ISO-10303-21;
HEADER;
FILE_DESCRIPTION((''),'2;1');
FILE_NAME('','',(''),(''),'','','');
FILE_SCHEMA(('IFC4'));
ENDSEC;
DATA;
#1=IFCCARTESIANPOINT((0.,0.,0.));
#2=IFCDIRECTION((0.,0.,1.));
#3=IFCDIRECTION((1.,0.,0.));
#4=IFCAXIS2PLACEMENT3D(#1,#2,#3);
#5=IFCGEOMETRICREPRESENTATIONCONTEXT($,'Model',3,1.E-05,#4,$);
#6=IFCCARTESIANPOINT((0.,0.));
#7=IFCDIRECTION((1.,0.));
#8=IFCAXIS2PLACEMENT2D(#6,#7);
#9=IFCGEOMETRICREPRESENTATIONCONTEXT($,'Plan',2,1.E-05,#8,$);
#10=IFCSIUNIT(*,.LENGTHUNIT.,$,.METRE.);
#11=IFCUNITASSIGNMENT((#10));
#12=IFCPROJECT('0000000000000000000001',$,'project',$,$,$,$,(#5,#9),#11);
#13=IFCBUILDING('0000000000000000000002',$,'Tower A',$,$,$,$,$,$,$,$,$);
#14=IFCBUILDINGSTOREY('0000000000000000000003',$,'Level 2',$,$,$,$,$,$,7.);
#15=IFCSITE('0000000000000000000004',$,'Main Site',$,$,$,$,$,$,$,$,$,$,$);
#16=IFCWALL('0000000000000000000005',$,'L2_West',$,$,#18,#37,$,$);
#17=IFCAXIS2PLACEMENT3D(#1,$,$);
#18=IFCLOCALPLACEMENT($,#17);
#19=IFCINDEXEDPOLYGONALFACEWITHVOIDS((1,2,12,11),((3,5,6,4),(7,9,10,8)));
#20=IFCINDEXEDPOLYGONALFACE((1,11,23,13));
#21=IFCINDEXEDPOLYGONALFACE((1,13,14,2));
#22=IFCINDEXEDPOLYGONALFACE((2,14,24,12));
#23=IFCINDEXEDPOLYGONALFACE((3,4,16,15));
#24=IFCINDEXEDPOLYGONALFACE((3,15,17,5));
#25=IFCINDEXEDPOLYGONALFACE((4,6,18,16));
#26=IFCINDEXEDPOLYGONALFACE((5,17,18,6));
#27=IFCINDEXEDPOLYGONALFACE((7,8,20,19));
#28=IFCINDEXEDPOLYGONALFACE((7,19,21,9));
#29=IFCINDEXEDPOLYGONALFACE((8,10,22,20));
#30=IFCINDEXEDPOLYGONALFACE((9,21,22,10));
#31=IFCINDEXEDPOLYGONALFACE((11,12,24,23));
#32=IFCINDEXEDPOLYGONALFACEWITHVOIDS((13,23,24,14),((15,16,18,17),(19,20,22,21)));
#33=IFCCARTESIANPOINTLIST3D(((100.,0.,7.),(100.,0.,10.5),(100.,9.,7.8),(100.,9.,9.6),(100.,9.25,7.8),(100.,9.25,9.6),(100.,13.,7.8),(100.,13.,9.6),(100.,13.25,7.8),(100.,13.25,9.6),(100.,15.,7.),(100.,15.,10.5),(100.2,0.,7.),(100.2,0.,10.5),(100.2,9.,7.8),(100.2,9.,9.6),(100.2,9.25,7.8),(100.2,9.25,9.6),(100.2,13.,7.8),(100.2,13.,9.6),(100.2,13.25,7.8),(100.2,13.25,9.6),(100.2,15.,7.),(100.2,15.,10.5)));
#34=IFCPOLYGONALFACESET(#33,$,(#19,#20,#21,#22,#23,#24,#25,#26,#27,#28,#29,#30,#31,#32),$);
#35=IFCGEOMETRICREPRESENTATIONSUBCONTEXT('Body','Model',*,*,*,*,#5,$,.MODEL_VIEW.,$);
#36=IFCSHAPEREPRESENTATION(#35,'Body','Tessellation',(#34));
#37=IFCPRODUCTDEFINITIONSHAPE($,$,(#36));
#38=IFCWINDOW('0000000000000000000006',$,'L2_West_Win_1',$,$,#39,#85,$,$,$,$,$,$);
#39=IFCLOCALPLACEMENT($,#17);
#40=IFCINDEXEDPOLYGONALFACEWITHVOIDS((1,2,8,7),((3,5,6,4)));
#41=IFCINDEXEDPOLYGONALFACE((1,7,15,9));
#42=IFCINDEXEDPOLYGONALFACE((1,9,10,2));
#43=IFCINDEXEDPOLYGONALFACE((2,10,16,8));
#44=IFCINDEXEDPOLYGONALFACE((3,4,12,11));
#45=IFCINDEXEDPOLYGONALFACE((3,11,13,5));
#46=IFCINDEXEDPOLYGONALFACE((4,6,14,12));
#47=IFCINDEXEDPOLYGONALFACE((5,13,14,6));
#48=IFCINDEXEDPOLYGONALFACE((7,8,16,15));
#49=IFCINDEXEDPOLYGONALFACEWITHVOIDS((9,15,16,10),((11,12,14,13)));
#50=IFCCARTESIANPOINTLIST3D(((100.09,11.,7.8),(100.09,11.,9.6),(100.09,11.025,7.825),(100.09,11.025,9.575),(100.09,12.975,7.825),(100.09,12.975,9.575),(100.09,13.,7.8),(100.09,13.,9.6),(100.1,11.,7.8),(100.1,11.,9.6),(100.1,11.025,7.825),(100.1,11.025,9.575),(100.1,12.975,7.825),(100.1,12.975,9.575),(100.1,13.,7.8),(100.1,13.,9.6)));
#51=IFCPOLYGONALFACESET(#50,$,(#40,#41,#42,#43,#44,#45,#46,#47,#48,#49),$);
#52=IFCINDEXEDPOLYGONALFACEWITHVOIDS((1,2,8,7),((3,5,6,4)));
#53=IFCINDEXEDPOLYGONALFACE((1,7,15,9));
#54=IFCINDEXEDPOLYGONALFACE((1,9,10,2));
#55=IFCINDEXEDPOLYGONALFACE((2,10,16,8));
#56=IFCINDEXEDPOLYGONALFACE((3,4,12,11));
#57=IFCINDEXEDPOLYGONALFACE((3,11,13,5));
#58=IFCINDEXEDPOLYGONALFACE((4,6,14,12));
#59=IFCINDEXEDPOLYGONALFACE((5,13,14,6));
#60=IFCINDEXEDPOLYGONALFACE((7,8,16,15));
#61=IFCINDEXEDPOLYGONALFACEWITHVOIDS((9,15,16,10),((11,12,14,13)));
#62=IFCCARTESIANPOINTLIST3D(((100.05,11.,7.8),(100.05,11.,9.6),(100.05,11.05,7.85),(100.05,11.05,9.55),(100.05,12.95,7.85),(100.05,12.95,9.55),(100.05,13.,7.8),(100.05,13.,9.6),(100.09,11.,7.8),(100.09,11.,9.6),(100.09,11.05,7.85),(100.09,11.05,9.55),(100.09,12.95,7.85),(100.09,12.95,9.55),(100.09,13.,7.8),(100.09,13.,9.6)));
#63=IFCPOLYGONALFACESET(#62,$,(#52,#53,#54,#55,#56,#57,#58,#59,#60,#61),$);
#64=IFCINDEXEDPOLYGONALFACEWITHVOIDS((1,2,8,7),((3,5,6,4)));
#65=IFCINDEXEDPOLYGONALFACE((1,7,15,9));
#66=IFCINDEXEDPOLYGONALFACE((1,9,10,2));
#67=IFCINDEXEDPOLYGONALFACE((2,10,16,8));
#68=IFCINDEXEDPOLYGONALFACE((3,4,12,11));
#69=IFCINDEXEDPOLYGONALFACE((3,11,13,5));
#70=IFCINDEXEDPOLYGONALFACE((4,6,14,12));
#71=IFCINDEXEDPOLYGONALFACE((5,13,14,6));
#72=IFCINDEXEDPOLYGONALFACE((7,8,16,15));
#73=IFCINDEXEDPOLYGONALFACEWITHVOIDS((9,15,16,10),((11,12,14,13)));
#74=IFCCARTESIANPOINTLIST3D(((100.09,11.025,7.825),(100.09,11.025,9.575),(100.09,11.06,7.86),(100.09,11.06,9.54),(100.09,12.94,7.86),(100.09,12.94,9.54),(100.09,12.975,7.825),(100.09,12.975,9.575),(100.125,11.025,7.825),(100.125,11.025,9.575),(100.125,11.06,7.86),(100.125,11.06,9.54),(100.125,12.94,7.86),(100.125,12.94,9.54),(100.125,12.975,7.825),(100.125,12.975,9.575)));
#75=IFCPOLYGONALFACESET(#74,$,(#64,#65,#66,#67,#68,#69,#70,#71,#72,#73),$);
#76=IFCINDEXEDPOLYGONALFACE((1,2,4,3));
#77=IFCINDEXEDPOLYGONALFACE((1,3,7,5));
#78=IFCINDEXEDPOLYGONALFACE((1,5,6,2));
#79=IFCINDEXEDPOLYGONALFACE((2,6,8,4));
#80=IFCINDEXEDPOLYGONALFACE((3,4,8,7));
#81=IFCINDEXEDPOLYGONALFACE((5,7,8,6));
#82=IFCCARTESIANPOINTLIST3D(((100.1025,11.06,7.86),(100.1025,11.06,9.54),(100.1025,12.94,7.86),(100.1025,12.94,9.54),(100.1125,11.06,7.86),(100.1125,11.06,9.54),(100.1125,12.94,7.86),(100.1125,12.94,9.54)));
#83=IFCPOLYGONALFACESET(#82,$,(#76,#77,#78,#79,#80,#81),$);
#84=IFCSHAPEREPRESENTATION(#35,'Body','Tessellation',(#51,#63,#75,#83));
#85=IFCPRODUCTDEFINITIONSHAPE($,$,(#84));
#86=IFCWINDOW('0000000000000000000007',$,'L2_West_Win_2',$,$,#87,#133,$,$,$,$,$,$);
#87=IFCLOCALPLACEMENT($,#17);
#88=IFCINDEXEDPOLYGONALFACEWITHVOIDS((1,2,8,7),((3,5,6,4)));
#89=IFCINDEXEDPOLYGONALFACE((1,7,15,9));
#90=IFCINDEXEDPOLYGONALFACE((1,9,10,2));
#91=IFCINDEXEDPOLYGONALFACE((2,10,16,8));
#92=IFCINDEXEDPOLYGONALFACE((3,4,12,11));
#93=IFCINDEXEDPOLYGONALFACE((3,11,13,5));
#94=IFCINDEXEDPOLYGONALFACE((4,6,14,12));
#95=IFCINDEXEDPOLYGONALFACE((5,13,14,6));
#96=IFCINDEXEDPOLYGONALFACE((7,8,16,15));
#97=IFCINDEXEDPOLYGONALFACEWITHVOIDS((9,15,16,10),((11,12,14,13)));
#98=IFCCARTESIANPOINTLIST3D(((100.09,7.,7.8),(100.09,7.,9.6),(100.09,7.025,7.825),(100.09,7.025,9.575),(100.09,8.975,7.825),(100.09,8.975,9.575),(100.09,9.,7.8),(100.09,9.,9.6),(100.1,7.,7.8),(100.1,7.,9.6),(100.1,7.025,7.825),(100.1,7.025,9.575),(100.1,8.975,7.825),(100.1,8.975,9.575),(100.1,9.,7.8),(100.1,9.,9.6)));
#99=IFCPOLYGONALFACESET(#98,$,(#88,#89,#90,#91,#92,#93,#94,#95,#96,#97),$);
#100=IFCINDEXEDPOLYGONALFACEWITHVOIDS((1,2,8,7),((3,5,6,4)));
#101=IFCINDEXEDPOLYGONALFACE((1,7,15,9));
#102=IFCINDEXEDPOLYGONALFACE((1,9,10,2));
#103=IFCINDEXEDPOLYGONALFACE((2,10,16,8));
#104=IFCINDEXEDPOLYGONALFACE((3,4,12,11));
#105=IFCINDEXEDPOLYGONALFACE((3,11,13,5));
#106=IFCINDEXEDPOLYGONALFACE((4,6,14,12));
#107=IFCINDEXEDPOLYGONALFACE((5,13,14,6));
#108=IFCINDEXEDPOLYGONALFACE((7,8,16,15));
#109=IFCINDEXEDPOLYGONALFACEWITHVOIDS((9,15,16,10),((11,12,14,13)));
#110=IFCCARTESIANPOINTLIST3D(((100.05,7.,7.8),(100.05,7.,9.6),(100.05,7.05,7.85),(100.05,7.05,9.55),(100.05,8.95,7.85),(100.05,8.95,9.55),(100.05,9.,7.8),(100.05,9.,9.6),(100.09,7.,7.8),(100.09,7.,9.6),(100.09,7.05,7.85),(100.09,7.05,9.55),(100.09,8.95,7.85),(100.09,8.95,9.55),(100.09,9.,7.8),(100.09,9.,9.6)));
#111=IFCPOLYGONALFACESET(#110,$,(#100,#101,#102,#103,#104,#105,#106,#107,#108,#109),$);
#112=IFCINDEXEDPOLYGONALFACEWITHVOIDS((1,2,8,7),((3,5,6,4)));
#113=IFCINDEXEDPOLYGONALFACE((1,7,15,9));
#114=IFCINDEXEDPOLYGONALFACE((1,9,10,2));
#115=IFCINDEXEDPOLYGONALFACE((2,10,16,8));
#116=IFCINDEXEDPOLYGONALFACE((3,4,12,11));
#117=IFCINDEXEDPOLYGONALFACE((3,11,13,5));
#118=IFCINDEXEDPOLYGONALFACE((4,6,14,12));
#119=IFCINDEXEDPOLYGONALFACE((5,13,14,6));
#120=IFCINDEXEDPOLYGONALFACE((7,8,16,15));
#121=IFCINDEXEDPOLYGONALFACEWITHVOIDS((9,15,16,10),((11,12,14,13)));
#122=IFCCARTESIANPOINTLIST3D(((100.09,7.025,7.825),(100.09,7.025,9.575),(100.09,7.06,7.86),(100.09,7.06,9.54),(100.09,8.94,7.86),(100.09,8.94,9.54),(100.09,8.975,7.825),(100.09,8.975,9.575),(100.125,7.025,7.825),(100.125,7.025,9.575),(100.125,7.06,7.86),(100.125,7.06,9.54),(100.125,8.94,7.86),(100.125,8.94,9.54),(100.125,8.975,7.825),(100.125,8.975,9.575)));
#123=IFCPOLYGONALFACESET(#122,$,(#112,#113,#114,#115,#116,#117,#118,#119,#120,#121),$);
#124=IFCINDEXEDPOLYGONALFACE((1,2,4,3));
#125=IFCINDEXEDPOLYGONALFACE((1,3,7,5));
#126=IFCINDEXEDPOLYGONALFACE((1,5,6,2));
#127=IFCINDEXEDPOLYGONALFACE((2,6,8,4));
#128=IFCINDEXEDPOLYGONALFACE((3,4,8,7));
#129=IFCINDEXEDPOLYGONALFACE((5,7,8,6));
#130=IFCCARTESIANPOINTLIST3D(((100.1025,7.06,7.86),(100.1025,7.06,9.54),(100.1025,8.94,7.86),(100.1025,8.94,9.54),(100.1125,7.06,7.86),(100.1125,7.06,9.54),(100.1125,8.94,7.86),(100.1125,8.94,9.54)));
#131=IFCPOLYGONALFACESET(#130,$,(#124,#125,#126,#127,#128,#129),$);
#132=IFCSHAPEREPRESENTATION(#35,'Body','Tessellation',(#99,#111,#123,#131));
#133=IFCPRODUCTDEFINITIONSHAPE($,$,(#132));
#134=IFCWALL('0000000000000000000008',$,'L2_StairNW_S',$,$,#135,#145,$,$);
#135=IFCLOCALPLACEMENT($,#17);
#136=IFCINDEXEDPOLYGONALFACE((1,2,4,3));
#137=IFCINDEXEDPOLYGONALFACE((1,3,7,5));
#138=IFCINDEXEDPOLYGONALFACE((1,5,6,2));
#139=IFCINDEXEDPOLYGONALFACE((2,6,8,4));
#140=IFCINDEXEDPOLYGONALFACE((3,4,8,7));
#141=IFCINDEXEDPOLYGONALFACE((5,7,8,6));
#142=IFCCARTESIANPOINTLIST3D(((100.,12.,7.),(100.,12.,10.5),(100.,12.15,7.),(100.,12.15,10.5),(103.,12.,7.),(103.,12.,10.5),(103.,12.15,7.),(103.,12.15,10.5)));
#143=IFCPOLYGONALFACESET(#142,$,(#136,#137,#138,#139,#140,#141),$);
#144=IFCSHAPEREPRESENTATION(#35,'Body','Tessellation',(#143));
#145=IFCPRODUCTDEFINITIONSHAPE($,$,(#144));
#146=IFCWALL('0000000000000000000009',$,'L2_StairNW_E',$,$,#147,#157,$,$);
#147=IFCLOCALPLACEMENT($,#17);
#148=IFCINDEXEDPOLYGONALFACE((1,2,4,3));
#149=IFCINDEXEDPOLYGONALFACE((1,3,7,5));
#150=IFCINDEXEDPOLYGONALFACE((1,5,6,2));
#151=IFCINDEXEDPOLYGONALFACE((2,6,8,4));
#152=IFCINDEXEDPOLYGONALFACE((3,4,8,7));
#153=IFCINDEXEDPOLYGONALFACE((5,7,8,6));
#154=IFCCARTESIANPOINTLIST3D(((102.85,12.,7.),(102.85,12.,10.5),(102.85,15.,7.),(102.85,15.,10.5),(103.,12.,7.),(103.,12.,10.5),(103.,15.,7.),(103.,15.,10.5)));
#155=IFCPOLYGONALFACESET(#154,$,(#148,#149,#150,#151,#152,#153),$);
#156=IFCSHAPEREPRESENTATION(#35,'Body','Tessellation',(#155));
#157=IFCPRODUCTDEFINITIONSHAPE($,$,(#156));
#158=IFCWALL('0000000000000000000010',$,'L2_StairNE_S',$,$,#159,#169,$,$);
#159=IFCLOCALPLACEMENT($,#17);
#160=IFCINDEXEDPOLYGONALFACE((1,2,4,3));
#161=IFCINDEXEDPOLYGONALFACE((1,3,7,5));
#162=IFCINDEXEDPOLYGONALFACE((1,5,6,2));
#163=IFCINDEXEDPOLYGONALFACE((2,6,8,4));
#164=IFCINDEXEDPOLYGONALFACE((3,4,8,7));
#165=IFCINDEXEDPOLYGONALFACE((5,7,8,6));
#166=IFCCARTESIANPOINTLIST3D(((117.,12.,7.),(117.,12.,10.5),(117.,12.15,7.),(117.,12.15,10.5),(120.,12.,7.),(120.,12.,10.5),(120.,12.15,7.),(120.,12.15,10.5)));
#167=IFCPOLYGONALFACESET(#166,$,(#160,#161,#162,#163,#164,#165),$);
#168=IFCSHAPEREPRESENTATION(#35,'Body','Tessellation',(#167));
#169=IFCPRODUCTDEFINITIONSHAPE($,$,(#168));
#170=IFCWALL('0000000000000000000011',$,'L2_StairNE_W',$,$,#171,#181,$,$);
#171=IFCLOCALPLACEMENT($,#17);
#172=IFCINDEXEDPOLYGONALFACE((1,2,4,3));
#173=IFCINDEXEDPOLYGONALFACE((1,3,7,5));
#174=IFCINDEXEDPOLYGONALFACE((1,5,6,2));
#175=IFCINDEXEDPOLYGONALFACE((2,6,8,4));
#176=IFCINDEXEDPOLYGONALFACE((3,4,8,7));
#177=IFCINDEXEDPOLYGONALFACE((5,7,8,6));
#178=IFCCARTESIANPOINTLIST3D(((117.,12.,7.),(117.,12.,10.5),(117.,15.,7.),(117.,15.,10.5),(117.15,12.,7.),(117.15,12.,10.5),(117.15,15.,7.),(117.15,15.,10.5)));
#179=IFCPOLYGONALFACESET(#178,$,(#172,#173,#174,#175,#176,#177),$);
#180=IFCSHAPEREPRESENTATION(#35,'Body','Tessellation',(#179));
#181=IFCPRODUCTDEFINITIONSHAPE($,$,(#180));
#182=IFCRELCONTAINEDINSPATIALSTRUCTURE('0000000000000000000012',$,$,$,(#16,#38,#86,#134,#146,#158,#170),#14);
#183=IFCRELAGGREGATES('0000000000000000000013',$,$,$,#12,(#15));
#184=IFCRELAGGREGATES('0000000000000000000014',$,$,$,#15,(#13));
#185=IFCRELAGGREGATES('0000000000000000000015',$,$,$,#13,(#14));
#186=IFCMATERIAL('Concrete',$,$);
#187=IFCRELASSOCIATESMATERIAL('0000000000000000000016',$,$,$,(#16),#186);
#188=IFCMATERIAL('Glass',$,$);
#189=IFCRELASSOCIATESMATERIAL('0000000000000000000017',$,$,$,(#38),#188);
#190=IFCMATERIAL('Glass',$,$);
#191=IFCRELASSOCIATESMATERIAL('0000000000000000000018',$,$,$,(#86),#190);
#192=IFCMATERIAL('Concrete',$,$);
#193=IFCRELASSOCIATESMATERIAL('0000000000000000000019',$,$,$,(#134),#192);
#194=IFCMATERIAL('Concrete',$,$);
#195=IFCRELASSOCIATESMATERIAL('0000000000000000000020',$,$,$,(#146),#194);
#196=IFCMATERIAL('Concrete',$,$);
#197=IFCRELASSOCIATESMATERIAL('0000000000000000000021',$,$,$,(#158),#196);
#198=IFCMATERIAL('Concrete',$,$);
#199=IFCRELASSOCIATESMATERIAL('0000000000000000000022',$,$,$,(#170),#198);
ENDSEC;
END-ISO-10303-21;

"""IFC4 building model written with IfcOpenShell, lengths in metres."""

from ifc_helpers import new_model, si_unit, frame, origin_with_axes, origin_2d_with_axis, place, context, subcontext, project, spatial, line, indexed_curve, outline, extrude, material, element, fill, save


model = new_model("IFC4")

# Units and contexts
model_context = context("Model", 3, precision=1e-05, world=origin_with_axes())
plan_context = context("Plan", 2, precision=1e-05, world=origin_2d_with_axis())
body_context = subcontext(model_context, "Body", "Model", "MODEL_VIEW")
ifc_project = project(units=[si_unit("LENGTHUNIT", "METRE")], contexts=[model_context, plan_context])

# Site, building, storey
site = spatial("IfcSite", under=ifc_project, Name="Main Site")
building = spatial("IfcBuilding", under=site, Name="Tower A")
storey = spatial("IfcBuildingStorey", under=building, Name="Level 2", Elevation=7.0)

# Wall, openings, windows
ifc_material_1 = material(Name="Concrete")
wall_1_placement = place(None, frame((100.0, 15.0, 7.0), z_axis=(0.0, 0.0, 1.0), x_axis=(0.0, -1.0, 0.0)))
wall_1 = element("IfcWall", 1, at=wall_1_placement, inside=storey, material=ifc_material_1, Name="L2_West", context=body_context, shape_type="SweptSolid", body=[
    extrude(outline(indexed_curve([(0.0, 0.0), (0.0, 0.2), (15.0, 0.2), (15.0, 0.0), (0.0, 0.0)], self_intersect=False)), origin_with_axes(), (0.0, 0.0, 1.0), 3.5),
])
opening_1_placement = place(wall_1_placement, frame((2.0, 0.0, 0.8), z_axis=(0.0, 0.0, 1.0), x_axis=(0.0, 1.0, 0.0)))
opening_1 = element("IfcOpeningElement", 2, at=opening_1_placement, cuts=wall_1, context=body_context, shape_type="SweptSolid", body=[
    extrude(outline(indexed_curve([(0.0, 0.0), (0.0, 0.25), (2.0, 0.25), (2.0, 0.0), (0.0, 0.0)], self_intersect=False)), origin_with_axes(), (0.0, 0.0, 1.0), 1.8),
])
opening_2_placement = place(wall_1_placement, frame((6.0, 0.0, 0.8), z_axis=(0.0, 0.0, 1.0), x_axis=(0.0, 1.0, 0.0)))
opening_2 = element("IfcOpeningElement", 3, at=opening_2_placement, cuts=wall_1, context=body_context, shape_type="SweptSolid", body=[
    extrude(outline(indexed_curve([(0.0, 0.0), (0.0, 0.25), (2.0, 0.25), (2.0, 0.0), (0.0, 0.0)], self_intersect=False)), origin_with_axes(), (0.0, 0.0, 1.0), 1.8),
])
ifc_material_2 = material(Name="Glass")
window_1_placement = place(None, frame((100.0, 13.0, 7.8), z_axis=(0.0, 0.0, 1.0), x_axis=(0.0, -1.0, 0.0)))
window_1 = element("IfcWindow", 4, at=window_1_placement, inside=storey, material=ifc_material_2, Name="L2_West_Win_1", context=body_context, shape_type="SweptSolid", body=[
    extrude(outline(indexed_curve([(0.0, 0.0), (2.0, 0.0), (2.0, 1.8), (0.0, 1.8)], segments=[line(1, 2, 3, 4, 1)]), holes=[indexed_curve([(0.025, 0.025), (1.975, 0.025), (1.975, 1.775), (0.025, 1.775)], segments=[line(1, 2, 3, 4, 1)])]), frame((0.0, 0.09, 0.0), z_axis=(0.0, -1.0, 0.0), x_axis=(1.0, 0.0, 0.0)), (0.0, 0.0, -1.0), 0.01),
    extrude(outline(indexed_curve([(0.0, 0.0), (2.0, 0.0), (2.0, 1.8), (0.0, 1.8)], segments=[line(1, 2, 3, 4, 1)]), holes=[indexed_curve([(0.05, 0.05), (1.95, 0.05), (1.95, 1.75), (0.05, 1.75)], segments=[line(1, 2, 3, 4, 1)])]), frame((0.0, 0.05, 0.0), z_axis=(0.0, -1.0, 0.0), x_axis=(1.0, 0.0, 0.0)), (0.0, 0.0, -1.0), 0.04),
    extrude(outline(indexed_curve([(0.0, 0.0), (1.95, 0.0), (1.95, 1.75), (0.0, 1.75)], segments=[line(1, 2, 3, 4, 1)]), holes=[indexed_curve([(0.035, 0.035), (1.915, 0.035), (1.915, 1.715), (0.035, 1.715)], segments=[line(1, 2, 3, 4, 1)])]), frame((0.025, 0.09, 0.025), z_axis=(0.0, -1.0, 0.0), x_axis=(1.0, 0.0, 0.0)), (0.0, 0.0, -1.0), 0.035),
    extrude(outline(indexed_curve([(0.035, 0.035), (1.915, 0.035), (1.915, 1.715), (0.035, 1.715)], segments=[line(1, 2, 3, 4, 1)])), frame((0.025, 0.1025, 0.025), z_axis=(0.0, -1.0, 0.0), x_axis=(1.0, 0.0, 0.0)), (0.0, 0.0, -1.0), 0.01),
])
fill(opening_1, window_1)
ifc_material_3 = material(Name="Glass")
window_2_placement = place(None, frame((100.0, 9.0, 7.8), z_axis=(0.0, 0.0, 1.0), x_axis=(0.0, -1.0, 0.0)))
window_2 = element("IfcWindow", 5, at=window_2_placement, inside=storey, material=ifc_material_3, Name="L2_West_Win_2", context=body_context, shape_type="SweptSolid", body=[
    extrude(outline(indexed_curve([(0.0, 0.0), (2.0, 0.0), (2.0, 1.8), (0.0, 1.8)], segments=[line(1, 2, 3, 4, 1)]), holes=[indexed_curve([(0.025, 0.025), (1.975, 0.025), (1.975, 1.775), (0.025, 1.775)], segments=[line(1, 2, 3, 4, 1)])]), frame((0.0, 0.09, 0.0), z_axis=(0.0, -1.0, 0.0), x_axis=(1.0, 0.0, 0.0)), (0.0, 0.0, -1.0), 0.01),
    extrude(outline(indexed_curve([(0.0, 0.0), (2.0, 0.0), (2.0, 1.8), (0.0, 1.8)], segments=[line(1, 2, 3, 4, 1)]), holes=[indexed_curve([(0.05, 0.05), (1.95, 0.05), (1.95, 1.75), (0.05, 1.75)], segments=[line(1, 2, 3, 4, 1)])]), frame((0.0, 0.05, 0.0), z_axis=(0.0, -1.0, 0.0), x_axis=(1.0, 0.0, 0.0)), (0.0, 0.0, -1.0), 0.04),
    extrude(outline(indexed_curve([(0.0, 0.0), (1.95, 0.0), (1.95, 1.75), (0.0, 1.75)], segments=[line(1, 2, 3, 4, 1)]), holes=[indexed_curve([(0.035, 0.035), (1.915, 0.035), (1.915, 1.715), (0.035, 1.715)], segments=[line(1, 2, 3, 4, 1)])]), frame((0.025, 0.09, 0.025), z_axis=(0.0, -1.0, 0.0), x_axis=(1.0, 0.0, 0.0)), (0.0, 0.0, -1.0), 0.035),
    extrude(outline(indexed_curve([(0.035, 0.035), (1.915, 0.035), (1.915, 1.715), (0.035, 1.715)], segments=[line(1, 2, 3, 4, 1)])), frame((0.025, 0.1025, 0.025), z_axis=(0.0, -1.0, 0.0), x_axis=(1.0, 0.0, 0.0)), (0.0, 0.0, -1.0), 0.01),
])
fill(opening_2, window_2)

# Walls
ifc_material_4 = material(Name="Concrete")
wall_2_placement = place(None, frame((100.0, 12.0, 7.0), z_axis=(0.0, 0.0, 1.0), x_axis=(1.0, 0.0, 0.0)))
element("IfcWall", 6, at=wall_2_placement, inside=storey, material=ifc_material_4, Name="L2_StairNW_S", context=body_context, shape_type="SweptSolid", body=[
    extrude(outline(indexed_curve([(0.0, 0.0), (0.0, 0.15), (3.0, 0.15), (3.0, 0.0), (0.0, 0.0)], self_intersect=False)), origin_with_axes(), (0.0, 0.0, 1.0), 3.5),
])
ifc_material_5 = material(Name="Concrete")
wall_3_placement = place(None, frame((103.0, 12.0, 7.0), z_axis=(0.0, 0.0, 1.0), x_axis=(0.0, 1.0, 0.0)))
element("IfcWall", 7, at=wall_3_placement, inside=storey, material=ifc_material_5, Name="L2_StairNW_E", context=body_context, shape_type="SweptSolid", body=[
    extrude(outline(indexed_curve([(0.0, 0.0), (0.0, 0.15), (3.0, 0.15), (3.0, 0.0), (0.0, 0.0)], self_intersect=False)), origin_with_axes(), (0.0, 0.0, 1.0), 3.5),
])
ifc_material_6 = material(Name="Concrete")
wall_4_placement = place(None, frame((117.0, 12.0, 7.0), z_axis=(0.0, 0.0, 1.0), x_axis=(1.0, 0.0, 0.0)))
element("IfcWall", 8, at=wall_4_placement, inside=storey, material=ifc_material_6, Name="L2_StairNE_S", context=body_context, shape_type="SweptSolid", body=[
    extrude(outline(indexed_curve([(0.0, 0.0), (0.0, 0.15), (3.0, 0.15), (3.0, 0.0), (0.0, 0.0)], self_intersect=False)), origin_with_axes(), (0.0, 0.0, 1.0), 3.5),
])
ifc_material_7 = material(Name="Concrete")
wall_5_placement = place(None, frame((117.0, 15.0, 7.0), z_axis=(0.0, 0.0, 1.0), x_axis=(0.0, -1.0, 0.0)))
element("IfcWall", 9, at=wall_5_placement, inside=storey, material=ifc_material_7, Name="L2_StairNE_W", context=body_context, shape_type="SweptSolid", body=[
    extrude(outline(indexed_curve([(0.0, 0.0), (0.0, 0.15), (3.0, 0.15), (3.0, 0.0), (0.0, 0.0)], self_intersect=False)), origin_with_axes(), (0.0, 0.0, 1.0), 3.5),
])

save(model, "model.ifc")
